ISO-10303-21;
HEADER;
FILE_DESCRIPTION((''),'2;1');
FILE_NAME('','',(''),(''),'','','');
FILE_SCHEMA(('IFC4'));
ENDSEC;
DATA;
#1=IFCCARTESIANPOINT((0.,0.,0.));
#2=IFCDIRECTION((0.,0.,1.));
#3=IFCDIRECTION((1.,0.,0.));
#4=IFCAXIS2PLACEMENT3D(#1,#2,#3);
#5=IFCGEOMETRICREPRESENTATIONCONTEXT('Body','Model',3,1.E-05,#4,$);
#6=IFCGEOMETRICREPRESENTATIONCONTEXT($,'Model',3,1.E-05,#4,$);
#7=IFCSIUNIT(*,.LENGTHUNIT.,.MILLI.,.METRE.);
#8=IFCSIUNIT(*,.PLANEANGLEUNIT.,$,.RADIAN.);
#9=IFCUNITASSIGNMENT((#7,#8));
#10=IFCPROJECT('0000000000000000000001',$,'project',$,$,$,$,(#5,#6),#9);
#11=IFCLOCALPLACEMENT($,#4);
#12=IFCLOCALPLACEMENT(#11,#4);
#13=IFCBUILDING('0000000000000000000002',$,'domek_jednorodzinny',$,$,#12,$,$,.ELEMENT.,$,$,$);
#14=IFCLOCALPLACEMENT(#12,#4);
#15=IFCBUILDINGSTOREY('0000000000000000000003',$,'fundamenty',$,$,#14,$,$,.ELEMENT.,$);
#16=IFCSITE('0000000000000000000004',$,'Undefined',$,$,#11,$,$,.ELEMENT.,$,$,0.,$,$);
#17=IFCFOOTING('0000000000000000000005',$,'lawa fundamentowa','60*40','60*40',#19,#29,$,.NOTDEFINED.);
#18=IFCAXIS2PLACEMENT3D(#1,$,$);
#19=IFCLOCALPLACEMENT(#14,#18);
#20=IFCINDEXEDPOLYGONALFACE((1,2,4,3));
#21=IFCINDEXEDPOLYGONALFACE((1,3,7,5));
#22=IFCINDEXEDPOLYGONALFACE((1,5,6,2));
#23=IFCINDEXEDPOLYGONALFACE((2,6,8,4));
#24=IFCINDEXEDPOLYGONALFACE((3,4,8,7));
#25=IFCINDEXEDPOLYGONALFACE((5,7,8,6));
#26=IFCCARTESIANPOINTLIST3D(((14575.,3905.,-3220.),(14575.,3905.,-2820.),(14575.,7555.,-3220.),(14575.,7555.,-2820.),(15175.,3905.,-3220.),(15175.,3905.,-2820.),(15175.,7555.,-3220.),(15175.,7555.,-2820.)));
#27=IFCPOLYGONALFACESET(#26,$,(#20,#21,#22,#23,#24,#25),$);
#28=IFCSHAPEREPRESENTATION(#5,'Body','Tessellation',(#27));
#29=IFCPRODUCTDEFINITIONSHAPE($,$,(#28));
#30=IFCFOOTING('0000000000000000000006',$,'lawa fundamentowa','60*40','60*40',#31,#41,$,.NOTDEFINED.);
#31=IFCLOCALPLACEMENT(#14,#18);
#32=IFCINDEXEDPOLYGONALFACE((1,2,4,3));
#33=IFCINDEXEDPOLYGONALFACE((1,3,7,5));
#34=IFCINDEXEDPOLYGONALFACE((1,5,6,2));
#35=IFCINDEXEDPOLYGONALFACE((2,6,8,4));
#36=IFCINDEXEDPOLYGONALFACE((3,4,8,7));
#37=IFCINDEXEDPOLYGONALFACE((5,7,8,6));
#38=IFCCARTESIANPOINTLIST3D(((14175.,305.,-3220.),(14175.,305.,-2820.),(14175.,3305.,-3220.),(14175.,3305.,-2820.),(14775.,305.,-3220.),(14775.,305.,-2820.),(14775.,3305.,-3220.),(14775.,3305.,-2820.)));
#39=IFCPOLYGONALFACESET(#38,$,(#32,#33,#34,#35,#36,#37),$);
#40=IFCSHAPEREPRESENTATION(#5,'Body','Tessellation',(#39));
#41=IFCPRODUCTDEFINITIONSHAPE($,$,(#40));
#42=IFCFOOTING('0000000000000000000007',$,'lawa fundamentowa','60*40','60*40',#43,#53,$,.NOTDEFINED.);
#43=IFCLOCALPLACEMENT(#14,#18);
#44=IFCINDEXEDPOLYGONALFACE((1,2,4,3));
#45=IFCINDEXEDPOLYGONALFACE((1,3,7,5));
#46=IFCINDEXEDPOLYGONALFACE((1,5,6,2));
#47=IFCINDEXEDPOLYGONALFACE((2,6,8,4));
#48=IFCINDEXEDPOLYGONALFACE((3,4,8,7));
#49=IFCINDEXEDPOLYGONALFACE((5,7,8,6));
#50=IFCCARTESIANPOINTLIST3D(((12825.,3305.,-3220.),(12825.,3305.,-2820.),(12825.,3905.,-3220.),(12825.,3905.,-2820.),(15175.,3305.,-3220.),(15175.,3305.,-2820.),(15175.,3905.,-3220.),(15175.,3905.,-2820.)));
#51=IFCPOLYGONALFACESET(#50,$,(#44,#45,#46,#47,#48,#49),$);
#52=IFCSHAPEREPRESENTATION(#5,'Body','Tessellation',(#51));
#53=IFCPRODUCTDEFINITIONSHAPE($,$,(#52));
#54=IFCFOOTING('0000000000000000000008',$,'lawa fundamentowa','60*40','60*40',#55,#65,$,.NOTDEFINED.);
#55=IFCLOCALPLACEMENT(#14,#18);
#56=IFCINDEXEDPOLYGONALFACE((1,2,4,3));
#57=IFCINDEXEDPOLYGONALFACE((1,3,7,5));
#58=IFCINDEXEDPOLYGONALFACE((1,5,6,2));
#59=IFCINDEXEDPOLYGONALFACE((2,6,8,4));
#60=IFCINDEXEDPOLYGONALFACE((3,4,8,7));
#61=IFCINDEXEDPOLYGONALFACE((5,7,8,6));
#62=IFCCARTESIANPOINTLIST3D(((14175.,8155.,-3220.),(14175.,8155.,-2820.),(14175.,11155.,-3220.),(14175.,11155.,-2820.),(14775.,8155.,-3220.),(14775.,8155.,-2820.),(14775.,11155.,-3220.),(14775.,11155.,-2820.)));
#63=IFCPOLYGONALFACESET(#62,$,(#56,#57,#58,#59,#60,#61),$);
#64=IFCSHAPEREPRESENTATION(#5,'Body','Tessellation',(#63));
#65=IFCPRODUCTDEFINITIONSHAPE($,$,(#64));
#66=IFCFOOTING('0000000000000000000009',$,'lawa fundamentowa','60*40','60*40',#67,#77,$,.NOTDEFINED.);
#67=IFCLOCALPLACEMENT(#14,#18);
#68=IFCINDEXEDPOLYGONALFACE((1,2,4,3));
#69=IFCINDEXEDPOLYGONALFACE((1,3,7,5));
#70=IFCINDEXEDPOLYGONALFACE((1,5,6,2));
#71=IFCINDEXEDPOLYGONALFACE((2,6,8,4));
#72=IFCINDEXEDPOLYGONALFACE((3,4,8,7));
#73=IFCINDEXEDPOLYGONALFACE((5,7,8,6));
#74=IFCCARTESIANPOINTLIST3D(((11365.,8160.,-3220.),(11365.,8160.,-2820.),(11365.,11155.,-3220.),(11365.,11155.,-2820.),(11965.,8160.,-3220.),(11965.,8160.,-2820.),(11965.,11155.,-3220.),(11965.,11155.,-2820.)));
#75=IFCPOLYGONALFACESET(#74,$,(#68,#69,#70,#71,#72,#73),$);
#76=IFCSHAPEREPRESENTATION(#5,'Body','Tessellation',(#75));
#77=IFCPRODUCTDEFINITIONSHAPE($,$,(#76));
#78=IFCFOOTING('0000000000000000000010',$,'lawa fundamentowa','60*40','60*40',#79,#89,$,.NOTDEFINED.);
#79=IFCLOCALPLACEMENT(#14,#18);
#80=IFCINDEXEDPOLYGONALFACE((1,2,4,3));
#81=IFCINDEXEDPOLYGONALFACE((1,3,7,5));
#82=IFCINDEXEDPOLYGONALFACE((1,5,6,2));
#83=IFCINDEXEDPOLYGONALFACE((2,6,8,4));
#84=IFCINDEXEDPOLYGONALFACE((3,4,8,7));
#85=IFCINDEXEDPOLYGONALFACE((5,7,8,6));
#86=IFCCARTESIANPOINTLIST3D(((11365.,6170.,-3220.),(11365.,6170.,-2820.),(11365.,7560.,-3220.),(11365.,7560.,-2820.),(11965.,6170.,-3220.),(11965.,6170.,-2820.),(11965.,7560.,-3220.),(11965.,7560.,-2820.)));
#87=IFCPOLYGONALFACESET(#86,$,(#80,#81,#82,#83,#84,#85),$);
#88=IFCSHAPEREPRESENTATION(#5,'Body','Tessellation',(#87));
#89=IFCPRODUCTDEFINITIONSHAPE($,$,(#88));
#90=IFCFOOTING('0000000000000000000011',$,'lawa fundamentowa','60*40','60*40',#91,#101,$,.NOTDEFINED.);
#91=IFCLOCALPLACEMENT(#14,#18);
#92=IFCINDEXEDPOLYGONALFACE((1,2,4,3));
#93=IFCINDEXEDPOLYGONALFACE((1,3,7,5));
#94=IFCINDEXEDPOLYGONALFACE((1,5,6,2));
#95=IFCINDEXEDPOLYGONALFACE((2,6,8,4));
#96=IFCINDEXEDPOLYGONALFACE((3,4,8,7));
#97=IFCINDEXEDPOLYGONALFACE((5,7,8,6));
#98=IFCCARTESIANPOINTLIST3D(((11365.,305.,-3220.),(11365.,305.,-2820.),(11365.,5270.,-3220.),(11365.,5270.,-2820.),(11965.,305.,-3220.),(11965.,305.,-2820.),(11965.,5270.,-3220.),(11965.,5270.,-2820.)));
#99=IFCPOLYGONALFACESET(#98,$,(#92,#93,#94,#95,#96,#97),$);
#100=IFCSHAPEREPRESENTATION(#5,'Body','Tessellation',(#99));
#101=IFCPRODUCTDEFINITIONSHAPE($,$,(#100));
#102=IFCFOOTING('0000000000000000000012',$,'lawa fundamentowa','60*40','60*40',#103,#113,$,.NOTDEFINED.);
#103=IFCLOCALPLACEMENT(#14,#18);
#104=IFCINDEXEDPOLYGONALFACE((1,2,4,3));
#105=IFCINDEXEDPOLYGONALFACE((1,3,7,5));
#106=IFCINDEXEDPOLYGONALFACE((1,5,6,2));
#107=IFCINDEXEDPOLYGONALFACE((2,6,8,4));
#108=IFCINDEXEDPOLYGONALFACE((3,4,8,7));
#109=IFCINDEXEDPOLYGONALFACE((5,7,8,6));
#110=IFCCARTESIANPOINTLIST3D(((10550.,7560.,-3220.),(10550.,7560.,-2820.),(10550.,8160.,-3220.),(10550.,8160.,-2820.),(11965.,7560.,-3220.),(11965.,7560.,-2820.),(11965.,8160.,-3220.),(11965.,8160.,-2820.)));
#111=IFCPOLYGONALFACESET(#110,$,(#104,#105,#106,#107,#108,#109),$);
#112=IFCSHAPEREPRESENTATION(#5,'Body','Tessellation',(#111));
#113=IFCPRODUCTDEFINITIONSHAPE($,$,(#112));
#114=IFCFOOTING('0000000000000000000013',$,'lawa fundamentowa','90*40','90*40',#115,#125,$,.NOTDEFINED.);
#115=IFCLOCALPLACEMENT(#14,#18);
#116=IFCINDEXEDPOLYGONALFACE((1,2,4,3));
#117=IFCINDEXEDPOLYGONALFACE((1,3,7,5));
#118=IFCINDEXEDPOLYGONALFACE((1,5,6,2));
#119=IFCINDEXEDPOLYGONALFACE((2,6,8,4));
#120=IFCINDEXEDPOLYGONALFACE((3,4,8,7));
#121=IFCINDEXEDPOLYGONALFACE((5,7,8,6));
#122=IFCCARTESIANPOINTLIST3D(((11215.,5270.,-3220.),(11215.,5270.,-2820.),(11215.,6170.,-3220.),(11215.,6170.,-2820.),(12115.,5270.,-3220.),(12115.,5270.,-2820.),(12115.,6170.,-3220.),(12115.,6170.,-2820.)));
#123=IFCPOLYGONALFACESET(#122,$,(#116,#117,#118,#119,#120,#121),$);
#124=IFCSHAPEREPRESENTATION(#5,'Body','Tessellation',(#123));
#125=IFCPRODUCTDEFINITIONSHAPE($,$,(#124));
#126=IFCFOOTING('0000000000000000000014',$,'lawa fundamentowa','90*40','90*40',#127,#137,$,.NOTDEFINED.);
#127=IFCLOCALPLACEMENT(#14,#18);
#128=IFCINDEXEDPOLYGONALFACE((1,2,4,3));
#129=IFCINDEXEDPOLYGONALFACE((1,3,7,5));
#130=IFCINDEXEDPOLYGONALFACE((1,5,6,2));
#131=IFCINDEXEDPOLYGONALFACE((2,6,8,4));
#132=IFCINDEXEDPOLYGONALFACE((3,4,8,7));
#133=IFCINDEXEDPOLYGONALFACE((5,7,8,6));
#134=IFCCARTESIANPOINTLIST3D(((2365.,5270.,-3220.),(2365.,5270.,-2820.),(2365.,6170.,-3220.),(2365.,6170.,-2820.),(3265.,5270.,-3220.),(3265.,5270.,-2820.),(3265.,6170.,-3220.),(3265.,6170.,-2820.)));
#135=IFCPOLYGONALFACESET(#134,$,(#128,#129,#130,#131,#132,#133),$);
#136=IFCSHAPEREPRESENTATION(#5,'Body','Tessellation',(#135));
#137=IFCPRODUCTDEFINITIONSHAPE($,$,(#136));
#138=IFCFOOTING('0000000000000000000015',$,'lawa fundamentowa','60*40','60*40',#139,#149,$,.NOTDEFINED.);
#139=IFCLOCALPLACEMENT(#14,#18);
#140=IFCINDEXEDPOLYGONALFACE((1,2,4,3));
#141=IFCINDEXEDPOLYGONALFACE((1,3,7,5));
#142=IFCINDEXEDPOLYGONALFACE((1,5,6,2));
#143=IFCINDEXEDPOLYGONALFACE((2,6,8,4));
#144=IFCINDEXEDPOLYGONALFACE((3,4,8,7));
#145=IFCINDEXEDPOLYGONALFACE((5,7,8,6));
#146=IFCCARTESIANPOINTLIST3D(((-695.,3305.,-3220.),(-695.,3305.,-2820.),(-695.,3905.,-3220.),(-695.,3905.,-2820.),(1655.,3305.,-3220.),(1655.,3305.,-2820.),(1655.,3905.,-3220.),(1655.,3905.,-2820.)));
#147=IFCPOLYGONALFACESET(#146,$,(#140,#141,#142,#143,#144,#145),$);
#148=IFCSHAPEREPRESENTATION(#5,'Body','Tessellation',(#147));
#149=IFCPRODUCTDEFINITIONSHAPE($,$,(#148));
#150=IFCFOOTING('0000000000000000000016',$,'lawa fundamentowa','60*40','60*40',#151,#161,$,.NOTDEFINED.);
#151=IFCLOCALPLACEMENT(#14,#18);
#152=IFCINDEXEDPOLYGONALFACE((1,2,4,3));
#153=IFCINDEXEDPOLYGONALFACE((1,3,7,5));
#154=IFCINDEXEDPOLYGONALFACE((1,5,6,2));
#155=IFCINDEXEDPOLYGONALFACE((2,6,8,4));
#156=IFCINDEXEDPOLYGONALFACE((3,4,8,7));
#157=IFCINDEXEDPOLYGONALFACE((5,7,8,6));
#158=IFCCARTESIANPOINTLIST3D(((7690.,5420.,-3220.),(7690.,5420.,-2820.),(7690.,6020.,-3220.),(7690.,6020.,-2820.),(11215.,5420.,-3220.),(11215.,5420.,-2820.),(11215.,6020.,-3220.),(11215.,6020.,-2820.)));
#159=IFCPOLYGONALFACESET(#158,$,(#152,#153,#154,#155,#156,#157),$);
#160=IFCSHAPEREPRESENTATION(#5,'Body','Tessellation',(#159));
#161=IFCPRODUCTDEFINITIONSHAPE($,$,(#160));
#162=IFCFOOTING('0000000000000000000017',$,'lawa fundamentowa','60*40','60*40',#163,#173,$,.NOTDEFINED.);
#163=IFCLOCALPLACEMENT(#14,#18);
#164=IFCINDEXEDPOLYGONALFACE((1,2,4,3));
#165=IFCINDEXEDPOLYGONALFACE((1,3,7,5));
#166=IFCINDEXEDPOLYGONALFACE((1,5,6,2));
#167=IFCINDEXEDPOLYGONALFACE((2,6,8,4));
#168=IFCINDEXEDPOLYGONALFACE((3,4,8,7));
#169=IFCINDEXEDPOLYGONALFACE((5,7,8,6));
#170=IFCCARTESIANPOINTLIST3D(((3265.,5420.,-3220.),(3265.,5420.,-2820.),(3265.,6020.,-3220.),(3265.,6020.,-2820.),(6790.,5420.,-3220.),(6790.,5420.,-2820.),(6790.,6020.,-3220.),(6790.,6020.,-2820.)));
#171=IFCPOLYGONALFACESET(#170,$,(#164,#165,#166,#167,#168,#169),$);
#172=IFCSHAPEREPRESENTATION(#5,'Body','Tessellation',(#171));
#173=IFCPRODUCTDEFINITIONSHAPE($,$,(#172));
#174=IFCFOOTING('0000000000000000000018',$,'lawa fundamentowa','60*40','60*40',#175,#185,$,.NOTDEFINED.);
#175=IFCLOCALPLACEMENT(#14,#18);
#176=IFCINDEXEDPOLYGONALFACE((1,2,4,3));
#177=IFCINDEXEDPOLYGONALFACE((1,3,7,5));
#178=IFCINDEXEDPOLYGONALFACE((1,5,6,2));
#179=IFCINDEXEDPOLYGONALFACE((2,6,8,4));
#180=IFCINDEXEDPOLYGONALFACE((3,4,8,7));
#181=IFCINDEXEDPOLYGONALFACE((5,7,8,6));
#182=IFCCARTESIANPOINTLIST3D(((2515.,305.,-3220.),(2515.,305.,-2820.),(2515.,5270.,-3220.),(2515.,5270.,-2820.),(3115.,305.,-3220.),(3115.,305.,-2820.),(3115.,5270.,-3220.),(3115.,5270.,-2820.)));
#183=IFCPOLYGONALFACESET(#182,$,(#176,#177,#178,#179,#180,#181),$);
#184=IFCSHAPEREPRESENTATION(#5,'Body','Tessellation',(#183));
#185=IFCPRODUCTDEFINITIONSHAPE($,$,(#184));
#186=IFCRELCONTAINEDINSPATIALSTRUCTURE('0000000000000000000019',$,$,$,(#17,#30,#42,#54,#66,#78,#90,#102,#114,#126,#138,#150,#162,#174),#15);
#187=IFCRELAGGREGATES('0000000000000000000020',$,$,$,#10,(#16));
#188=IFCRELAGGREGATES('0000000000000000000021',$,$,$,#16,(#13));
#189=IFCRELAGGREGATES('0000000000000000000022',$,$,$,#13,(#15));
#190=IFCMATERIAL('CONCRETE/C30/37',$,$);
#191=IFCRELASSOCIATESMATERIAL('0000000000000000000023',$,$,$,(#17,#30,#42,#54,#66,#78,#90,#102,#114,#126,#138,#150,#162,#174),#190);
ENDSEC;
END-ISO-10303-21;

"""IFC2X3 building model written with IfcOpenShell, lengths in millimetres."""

from ifc_helpers import new_model, si_unit, frame, origin_with_axes, origin_2d_with_axis, place, context, project, spatial, rectangle, extrude, material, element, save


model = new_model("IFC2X3")

# Units and contexts
model_context_1 = context("Model", 3, precision=1e-05, world=origin_with_axes(), identifier="Body")
model_context_2 = context("Model", 3, precision=1e-05, world=origin_with_axes())
ifc_project = project(units=[si_unit("LENGTHUNIT", "METRE", prefix="MILLI"), si_unit("PLANEANGLEUNIT", "RADIAN")], contexts=[model_context_1, model_context_2])

# Site, building, storey
site_placement = place(None, origin_with_axes())
site = spatial("IfcSite", under=ifc_project, at=site_placement, Name="Undefined", CompositionType="ELEMENT", RefElevation=0.0)
building_placement = place(site_placement, origin_with_axes())
building = spatial("IfcBuilding", under=site, at=building_placement, Name="domek_jednorodzinny", CompositionType="ELEMENT")
storey_placement = place(building_placement, origin_with_axes())
storey = spatial("IfcBuildingStorey", under=building, at=storey_placement, Name="fundamenty", CompositionType="ELEMENT")

# Shared definitions
ifc_material = material(Name="CONCRETE/C30/37")

# Footings
footing_1_placement = place(storey_placement, frame((14875.0, 3905.0, -3020.0), z_axis=(0.0, 0.0, 1.0), x_axis=(0.0, 1.0, 0.0)))
element("IfcFooting", 1, at=footing_1_placement, inside=storey, material=ifc_material, Name="lawa fundamentowa", Description="60*40", ObjectType="60*40", PredefinedType="NOTDEFINED", context=model_context_1, shape_type="SweptSolid", body=[
    extrude(rectangle(XDim=600.0, YDim=400.0, at=origin_2d_with_axis()), frame((3650.0, 0.0, 0.0), z_axis=(-1.0, 0.0, 0.0), x_axis=(0.0, -1.0, 0.0)), (0.0, 0.0, 1.0), 3650.0),
])
footing_2_placement = place(storey_placement, frame((14475.0, 305.0, -3020.0), z_axis=(0.0, 0.0, 1.0), x_axis=(0.0, 1.0, 0.0)))
element("IfcFooting", 2, at=footing_2_placement, inside=storey, material=ifc_material, Name="lawa fundamentowa", Description="60*40", ObjectType="60*40", PredefinedType="NOTDEFINED", context=model_context_1, shape_type="SweptSolid", body=[
    extrude(rectangle(XDim=600.0, YDim=400.0, at=origin_2d_with_axis()), frame((3000.0, 0.0, 0.0), z_axis=(-1.0, 0.0, 0.0), x_axis=(0.0, -1.0, 0.0)), (0.0, 0.0, 1.0), 3000.0),
])
footing_3_placement = place(storey_placement, frame((12825.0, 3605.0, -3020.0), z_axis=(0.0, 0.0, 1.0), x_axis=(1.0, 0.0, 0.0)))
element("IfcFooting", 3, at=footing_3_placement, inside=storey, material=ifc_material, Name="lawa fundamentowa", Description="60*40", ObjectType="60*40", PredefinedType="NOTDEFINED", context=model_context_1, shape_type="SweptSolid", body=[
    extrude(rectangle(XDim=600.0, YDim=400.0, at=origin_2d_with_axis()), frame((2350.0, 0.0, 0.0), z_axis=(-1.0, 0.0, 0.0), x_axis=(0.0, -1.0, 0.0)), (0.0, 0.0, 1.0), 2350.0),
])
footing_4_placement = place(storey_placement, frame((14475.0, 8155.0, -3020.0), z_axis=(0.0, 0.0, 1.0), x_axis=(0.0, 1.0, 0.0)))
element("IfcFooting", 4, at=footing_4_placement, inside=storey, material=ifc_material, Name="lawa fundamentowa", Description="60*40", ObjectType="60*40", PredefinedType="NOTDEFINED", context=model_context_1, shape_type="SweptSolid", body=[
    extrude(rectangle(XDim=600.0, YDim=400.0, at=origin_2d_with_axis()), frame((3000.0, 0.0, 0.0), z_axis=(-1.0, 0.0, 0.0), x_axis=(0.0, -1.0, 0.0)), (0.0, 0.0, 1.0), 3000.0),
])
footing_5_placement = place(storey_placement, frame((11665.0, 8160.0, -3020.0), z_axis=(0.0, 0.0, 1.0), x_axis=(0.0, 1.0, 0.0)))
element("IfcFooting", 5, at=footing_5_placement, inside=storey, material=ifc_material, Name="lawa fundamentowa", Description="60*40", ObjectType="60*40", PredefinedType="NOTDEFINED", context=model_context_1, shape_type="SweptSolid", body=[
    extrude(rectangle(XDim=600.0, YDim=400.0, at=origin_2d_with_axis()), frame((2995.0, 0.0, 0.0), z_axis=(-1.0, 0.0, 0.0), x_axis=(0.0, -1.0, 0.0)), (0.0, 0.0, 1.0), 2995.0),
])
footing_6_placement = place(storey_placement, frame((11665.0, 6170.0, -3020.0), z_axis=(0.0, 0.0, 1.0), x_axis=(0.0, 1.0, 0.0)))
element("IfcFooting", 6, at=footing_6_placement, inside=storey, material=ifc_material, Name="lawa fundamentowa", Description="60*40", ObjectType="60*40", PredefinedType="NOTDEFINED", context=model_context_1, shape_type="SweptSolid", body=[
    extrude(rectangle(XDim=600.0, YDim=400.0, at=origin_2d_with_axis()), frame((1390.0, 0.0, 0.0), z_axis=(-1.0, 0.0, 0.0), x_axis=(0.0, -1.0, 0.0)), (0.0, 0.0, 1.0), 1390.0),
])
footing_7_placement = place(storey_placement, frame((11665.0, 305.0, -3020.0), z_axis=(0.0, 0.0, 1.0), x_axis=(0.0, 1.0, 0.0)))
element("IfcFooting", 7, at=footing_7_placement, inside=storey, material=ifc_material, Name="lawa fundamentowa", Description="60*40", ObjectType="60*40", PredefinedType="NOTDEFINED", context=model_context_1, shape_type="SweptSolid", body=[
    extrude(rectangle(XDim=600.0, YDim=400.0, at=origin_2d_with_axis()), frame((4965.0, 0.0, 0.0), z_axis=(-1.0, 0.0, 0.0), x_axis=(0.0, -1.0, 0.0)), (0.0, 0.0, 1.0), 4965.0),
])
footing_8_placement = place(storey_placement, frame((10550.0, 7860.0, -3020.0), z_axis=(0.0, 0.0, 1.0), x_axis=(1.0, 0.0, 0.0)))
element("IfcFooting", 8, at=footing_8_placement, inside=storey, material=ifc_material, Name="lawa fundamentowa", Description="60*40", ObjectType="60*40", PredefinedType="NOTDEFINED", context=model_context_1, shape_type="SweptSolid", body=[
    extrude(rectangle(XDim=600.0, YDim=400.0, at=origin_2d_with_axis()), frame((1415.0, 0.0, 0.0), z_axis=(-1.0, 0.0, 0.0), x_axis=(0.0, -1.0, 0.0)), (0.0, 0.0, 1.0), 1415.0),
])
footing_9_placement = place(storey_placement, frame((11215.0, 5720.0, -3020.0), z_axis=(0.0, 0.0, 1.0), x_axis=(1.0, 0.0, 0.0)))
element("IfcFooting", 9, at=footing_9_placement, inside=storey, material=ifc_material, Name="lawa fundamentowa", Description="90*40", ObjectType="90*40", PredefinedType="NOTDEFINED", context=model_context_1, shape_type="SweptSolid", body=[
    extrude(rectangle(XDim=900.0, YDim=400.0, at=origin_2d_with_axis()), frame((900.0, 0.0, 0.0), z_axis=(-1.0, 0.0, 0.0), x_axis=(0.0, -1.0, 0.0)), (0.0, 0.0, 1.0), 900.0),
])
footing_10_placement = place(storey_placement, frame((2365.0, 5720.0, -3020.0), z_axis=(0.0, 0.0, 1.0), x_axis=(1.0, 0.0, 0.0)))
element("IfcFooting", 10, at=footing_10_placement, inside=storey, material=ifc_material, Name="lawa fundamentowa", Description="90*40", ObjectType="90*40", PredefinedType="NOTDEFINED", context=model_context_1, shape_type="SweptSolid", body=[
    extrude(rectangle(XDim=900.0, YDim=400.0, at=origin_2d_with_axis()), frame((900.0, 0.0, 0.0), z_axis=(-1.0, 0.0, 0.0), x_axis=(0.0, -1.0, 0.0)), (0.0, 0.0, 1.0), 900.0),
])
footing_11_placement = place(storey_placement, frame((-695.0, 3605.0, -3020.0), z_axis=(0.0, 0.0, 1.0), x_axis=(1.0, 0.0, 0.0)))
element("IfcFooting", 11, at=footing_11_placement, inside=storey, material=ifc_material, Name="lawa fundamentowa", Description="60*40", ObjectType="60*40", PredefinedType="NOTDEFINED", context=model_context_1, shape_type="SweptSolid", body=[
    extrude(rectangle(XDim=600.0, YDim=400.0, at=origin_2d_with_axis()), frame((2350.0, 0.0, 0.0), z_axis=(-1.0, 0.0, 0.0), x_axis=(0.0, -1.0, 0.0)), (0.0, 0.0, 1.0), 2350.0),
])
footing_12_placement = place(storey_placement, frame((7690.0, 5720.0, -3020.0), z_axis=(0.0, 0.0, 1.0), x_axis=(1.0, 0.0, 0.0)))
element("IfcFooting", 12, at=footing_12_placement, inside=storey, material=ifc_material, Name="lawa fundamentowa", Description="60*40", ObjectType="60*40", PredefinedType="NOTDEFINED", context=model_context_1, shape_type="SweptSolid", body=[
    extrude(rectangle(XDim=600.0, YDim=400.0, at=origin_2d_with_axis()), frame((3525.0, 0.0, 0.0), z_axis=(-1.0, 0.0, 0.0), x_axis=(0.0, -1.0, 0.0)), (0.0, 0.0, 1.0), 3525.0),
])
footing_13_placement = place(storey_placement, frame((3265.0, 5720.0, -3020.0), z_axis=(0.0, 0.0, 1.0), x_axis=(1.0, 0.0, 0.0)))
element("IfcFooting", 13, at=footing_13_placement, inside=storey, material=ifc_material, Name="lawa fundamentowa", Description="60*40", ObjectType="60*40", PredefinedType="NOTDEFINED", context=model_context_1, shape_type="SweptSolid", body=[
    extrude(rectangle(XDim=600.0, YDim=400.0, at=origin_2d_with_axis()), frame((3525.0, 0.0, 0.0), z_axis=(-1.0, 0.0, 0.0), x_axis=(0.0, -1.0, 0.0)), (0.0, 0.0, 1.0), 3525.0),
])
footing_14_placement = place(storey_placement, frame((2815.0, 305.0, -3020.0), z_axis=(0.0, 0.0, 1.0), x_axis=(0.0, 1.0, 0.0)))
element("IfcFooting", 14, at=footing_14_placement, inside=storey, material=ifc_material, Name="lawa fundamentowa", Description="60*40", ObjectType="60*40", PredefinedType="NOTDEFINED", context=model_context_1, shape_type="SweptSolid", body=[
    extrude(rectangle(XDim=600.0, YDim=400.0, at=origin_2d_with_axis()), frame((4965.0, 0.0, 0.0), z_axis=(-1.0, 0.0, 0.0), x_axis=(0.0, -1.0, 0.0)), (0.0, 0.0, 1.0), 4965.0),
])

save(model, "model.ifc")
